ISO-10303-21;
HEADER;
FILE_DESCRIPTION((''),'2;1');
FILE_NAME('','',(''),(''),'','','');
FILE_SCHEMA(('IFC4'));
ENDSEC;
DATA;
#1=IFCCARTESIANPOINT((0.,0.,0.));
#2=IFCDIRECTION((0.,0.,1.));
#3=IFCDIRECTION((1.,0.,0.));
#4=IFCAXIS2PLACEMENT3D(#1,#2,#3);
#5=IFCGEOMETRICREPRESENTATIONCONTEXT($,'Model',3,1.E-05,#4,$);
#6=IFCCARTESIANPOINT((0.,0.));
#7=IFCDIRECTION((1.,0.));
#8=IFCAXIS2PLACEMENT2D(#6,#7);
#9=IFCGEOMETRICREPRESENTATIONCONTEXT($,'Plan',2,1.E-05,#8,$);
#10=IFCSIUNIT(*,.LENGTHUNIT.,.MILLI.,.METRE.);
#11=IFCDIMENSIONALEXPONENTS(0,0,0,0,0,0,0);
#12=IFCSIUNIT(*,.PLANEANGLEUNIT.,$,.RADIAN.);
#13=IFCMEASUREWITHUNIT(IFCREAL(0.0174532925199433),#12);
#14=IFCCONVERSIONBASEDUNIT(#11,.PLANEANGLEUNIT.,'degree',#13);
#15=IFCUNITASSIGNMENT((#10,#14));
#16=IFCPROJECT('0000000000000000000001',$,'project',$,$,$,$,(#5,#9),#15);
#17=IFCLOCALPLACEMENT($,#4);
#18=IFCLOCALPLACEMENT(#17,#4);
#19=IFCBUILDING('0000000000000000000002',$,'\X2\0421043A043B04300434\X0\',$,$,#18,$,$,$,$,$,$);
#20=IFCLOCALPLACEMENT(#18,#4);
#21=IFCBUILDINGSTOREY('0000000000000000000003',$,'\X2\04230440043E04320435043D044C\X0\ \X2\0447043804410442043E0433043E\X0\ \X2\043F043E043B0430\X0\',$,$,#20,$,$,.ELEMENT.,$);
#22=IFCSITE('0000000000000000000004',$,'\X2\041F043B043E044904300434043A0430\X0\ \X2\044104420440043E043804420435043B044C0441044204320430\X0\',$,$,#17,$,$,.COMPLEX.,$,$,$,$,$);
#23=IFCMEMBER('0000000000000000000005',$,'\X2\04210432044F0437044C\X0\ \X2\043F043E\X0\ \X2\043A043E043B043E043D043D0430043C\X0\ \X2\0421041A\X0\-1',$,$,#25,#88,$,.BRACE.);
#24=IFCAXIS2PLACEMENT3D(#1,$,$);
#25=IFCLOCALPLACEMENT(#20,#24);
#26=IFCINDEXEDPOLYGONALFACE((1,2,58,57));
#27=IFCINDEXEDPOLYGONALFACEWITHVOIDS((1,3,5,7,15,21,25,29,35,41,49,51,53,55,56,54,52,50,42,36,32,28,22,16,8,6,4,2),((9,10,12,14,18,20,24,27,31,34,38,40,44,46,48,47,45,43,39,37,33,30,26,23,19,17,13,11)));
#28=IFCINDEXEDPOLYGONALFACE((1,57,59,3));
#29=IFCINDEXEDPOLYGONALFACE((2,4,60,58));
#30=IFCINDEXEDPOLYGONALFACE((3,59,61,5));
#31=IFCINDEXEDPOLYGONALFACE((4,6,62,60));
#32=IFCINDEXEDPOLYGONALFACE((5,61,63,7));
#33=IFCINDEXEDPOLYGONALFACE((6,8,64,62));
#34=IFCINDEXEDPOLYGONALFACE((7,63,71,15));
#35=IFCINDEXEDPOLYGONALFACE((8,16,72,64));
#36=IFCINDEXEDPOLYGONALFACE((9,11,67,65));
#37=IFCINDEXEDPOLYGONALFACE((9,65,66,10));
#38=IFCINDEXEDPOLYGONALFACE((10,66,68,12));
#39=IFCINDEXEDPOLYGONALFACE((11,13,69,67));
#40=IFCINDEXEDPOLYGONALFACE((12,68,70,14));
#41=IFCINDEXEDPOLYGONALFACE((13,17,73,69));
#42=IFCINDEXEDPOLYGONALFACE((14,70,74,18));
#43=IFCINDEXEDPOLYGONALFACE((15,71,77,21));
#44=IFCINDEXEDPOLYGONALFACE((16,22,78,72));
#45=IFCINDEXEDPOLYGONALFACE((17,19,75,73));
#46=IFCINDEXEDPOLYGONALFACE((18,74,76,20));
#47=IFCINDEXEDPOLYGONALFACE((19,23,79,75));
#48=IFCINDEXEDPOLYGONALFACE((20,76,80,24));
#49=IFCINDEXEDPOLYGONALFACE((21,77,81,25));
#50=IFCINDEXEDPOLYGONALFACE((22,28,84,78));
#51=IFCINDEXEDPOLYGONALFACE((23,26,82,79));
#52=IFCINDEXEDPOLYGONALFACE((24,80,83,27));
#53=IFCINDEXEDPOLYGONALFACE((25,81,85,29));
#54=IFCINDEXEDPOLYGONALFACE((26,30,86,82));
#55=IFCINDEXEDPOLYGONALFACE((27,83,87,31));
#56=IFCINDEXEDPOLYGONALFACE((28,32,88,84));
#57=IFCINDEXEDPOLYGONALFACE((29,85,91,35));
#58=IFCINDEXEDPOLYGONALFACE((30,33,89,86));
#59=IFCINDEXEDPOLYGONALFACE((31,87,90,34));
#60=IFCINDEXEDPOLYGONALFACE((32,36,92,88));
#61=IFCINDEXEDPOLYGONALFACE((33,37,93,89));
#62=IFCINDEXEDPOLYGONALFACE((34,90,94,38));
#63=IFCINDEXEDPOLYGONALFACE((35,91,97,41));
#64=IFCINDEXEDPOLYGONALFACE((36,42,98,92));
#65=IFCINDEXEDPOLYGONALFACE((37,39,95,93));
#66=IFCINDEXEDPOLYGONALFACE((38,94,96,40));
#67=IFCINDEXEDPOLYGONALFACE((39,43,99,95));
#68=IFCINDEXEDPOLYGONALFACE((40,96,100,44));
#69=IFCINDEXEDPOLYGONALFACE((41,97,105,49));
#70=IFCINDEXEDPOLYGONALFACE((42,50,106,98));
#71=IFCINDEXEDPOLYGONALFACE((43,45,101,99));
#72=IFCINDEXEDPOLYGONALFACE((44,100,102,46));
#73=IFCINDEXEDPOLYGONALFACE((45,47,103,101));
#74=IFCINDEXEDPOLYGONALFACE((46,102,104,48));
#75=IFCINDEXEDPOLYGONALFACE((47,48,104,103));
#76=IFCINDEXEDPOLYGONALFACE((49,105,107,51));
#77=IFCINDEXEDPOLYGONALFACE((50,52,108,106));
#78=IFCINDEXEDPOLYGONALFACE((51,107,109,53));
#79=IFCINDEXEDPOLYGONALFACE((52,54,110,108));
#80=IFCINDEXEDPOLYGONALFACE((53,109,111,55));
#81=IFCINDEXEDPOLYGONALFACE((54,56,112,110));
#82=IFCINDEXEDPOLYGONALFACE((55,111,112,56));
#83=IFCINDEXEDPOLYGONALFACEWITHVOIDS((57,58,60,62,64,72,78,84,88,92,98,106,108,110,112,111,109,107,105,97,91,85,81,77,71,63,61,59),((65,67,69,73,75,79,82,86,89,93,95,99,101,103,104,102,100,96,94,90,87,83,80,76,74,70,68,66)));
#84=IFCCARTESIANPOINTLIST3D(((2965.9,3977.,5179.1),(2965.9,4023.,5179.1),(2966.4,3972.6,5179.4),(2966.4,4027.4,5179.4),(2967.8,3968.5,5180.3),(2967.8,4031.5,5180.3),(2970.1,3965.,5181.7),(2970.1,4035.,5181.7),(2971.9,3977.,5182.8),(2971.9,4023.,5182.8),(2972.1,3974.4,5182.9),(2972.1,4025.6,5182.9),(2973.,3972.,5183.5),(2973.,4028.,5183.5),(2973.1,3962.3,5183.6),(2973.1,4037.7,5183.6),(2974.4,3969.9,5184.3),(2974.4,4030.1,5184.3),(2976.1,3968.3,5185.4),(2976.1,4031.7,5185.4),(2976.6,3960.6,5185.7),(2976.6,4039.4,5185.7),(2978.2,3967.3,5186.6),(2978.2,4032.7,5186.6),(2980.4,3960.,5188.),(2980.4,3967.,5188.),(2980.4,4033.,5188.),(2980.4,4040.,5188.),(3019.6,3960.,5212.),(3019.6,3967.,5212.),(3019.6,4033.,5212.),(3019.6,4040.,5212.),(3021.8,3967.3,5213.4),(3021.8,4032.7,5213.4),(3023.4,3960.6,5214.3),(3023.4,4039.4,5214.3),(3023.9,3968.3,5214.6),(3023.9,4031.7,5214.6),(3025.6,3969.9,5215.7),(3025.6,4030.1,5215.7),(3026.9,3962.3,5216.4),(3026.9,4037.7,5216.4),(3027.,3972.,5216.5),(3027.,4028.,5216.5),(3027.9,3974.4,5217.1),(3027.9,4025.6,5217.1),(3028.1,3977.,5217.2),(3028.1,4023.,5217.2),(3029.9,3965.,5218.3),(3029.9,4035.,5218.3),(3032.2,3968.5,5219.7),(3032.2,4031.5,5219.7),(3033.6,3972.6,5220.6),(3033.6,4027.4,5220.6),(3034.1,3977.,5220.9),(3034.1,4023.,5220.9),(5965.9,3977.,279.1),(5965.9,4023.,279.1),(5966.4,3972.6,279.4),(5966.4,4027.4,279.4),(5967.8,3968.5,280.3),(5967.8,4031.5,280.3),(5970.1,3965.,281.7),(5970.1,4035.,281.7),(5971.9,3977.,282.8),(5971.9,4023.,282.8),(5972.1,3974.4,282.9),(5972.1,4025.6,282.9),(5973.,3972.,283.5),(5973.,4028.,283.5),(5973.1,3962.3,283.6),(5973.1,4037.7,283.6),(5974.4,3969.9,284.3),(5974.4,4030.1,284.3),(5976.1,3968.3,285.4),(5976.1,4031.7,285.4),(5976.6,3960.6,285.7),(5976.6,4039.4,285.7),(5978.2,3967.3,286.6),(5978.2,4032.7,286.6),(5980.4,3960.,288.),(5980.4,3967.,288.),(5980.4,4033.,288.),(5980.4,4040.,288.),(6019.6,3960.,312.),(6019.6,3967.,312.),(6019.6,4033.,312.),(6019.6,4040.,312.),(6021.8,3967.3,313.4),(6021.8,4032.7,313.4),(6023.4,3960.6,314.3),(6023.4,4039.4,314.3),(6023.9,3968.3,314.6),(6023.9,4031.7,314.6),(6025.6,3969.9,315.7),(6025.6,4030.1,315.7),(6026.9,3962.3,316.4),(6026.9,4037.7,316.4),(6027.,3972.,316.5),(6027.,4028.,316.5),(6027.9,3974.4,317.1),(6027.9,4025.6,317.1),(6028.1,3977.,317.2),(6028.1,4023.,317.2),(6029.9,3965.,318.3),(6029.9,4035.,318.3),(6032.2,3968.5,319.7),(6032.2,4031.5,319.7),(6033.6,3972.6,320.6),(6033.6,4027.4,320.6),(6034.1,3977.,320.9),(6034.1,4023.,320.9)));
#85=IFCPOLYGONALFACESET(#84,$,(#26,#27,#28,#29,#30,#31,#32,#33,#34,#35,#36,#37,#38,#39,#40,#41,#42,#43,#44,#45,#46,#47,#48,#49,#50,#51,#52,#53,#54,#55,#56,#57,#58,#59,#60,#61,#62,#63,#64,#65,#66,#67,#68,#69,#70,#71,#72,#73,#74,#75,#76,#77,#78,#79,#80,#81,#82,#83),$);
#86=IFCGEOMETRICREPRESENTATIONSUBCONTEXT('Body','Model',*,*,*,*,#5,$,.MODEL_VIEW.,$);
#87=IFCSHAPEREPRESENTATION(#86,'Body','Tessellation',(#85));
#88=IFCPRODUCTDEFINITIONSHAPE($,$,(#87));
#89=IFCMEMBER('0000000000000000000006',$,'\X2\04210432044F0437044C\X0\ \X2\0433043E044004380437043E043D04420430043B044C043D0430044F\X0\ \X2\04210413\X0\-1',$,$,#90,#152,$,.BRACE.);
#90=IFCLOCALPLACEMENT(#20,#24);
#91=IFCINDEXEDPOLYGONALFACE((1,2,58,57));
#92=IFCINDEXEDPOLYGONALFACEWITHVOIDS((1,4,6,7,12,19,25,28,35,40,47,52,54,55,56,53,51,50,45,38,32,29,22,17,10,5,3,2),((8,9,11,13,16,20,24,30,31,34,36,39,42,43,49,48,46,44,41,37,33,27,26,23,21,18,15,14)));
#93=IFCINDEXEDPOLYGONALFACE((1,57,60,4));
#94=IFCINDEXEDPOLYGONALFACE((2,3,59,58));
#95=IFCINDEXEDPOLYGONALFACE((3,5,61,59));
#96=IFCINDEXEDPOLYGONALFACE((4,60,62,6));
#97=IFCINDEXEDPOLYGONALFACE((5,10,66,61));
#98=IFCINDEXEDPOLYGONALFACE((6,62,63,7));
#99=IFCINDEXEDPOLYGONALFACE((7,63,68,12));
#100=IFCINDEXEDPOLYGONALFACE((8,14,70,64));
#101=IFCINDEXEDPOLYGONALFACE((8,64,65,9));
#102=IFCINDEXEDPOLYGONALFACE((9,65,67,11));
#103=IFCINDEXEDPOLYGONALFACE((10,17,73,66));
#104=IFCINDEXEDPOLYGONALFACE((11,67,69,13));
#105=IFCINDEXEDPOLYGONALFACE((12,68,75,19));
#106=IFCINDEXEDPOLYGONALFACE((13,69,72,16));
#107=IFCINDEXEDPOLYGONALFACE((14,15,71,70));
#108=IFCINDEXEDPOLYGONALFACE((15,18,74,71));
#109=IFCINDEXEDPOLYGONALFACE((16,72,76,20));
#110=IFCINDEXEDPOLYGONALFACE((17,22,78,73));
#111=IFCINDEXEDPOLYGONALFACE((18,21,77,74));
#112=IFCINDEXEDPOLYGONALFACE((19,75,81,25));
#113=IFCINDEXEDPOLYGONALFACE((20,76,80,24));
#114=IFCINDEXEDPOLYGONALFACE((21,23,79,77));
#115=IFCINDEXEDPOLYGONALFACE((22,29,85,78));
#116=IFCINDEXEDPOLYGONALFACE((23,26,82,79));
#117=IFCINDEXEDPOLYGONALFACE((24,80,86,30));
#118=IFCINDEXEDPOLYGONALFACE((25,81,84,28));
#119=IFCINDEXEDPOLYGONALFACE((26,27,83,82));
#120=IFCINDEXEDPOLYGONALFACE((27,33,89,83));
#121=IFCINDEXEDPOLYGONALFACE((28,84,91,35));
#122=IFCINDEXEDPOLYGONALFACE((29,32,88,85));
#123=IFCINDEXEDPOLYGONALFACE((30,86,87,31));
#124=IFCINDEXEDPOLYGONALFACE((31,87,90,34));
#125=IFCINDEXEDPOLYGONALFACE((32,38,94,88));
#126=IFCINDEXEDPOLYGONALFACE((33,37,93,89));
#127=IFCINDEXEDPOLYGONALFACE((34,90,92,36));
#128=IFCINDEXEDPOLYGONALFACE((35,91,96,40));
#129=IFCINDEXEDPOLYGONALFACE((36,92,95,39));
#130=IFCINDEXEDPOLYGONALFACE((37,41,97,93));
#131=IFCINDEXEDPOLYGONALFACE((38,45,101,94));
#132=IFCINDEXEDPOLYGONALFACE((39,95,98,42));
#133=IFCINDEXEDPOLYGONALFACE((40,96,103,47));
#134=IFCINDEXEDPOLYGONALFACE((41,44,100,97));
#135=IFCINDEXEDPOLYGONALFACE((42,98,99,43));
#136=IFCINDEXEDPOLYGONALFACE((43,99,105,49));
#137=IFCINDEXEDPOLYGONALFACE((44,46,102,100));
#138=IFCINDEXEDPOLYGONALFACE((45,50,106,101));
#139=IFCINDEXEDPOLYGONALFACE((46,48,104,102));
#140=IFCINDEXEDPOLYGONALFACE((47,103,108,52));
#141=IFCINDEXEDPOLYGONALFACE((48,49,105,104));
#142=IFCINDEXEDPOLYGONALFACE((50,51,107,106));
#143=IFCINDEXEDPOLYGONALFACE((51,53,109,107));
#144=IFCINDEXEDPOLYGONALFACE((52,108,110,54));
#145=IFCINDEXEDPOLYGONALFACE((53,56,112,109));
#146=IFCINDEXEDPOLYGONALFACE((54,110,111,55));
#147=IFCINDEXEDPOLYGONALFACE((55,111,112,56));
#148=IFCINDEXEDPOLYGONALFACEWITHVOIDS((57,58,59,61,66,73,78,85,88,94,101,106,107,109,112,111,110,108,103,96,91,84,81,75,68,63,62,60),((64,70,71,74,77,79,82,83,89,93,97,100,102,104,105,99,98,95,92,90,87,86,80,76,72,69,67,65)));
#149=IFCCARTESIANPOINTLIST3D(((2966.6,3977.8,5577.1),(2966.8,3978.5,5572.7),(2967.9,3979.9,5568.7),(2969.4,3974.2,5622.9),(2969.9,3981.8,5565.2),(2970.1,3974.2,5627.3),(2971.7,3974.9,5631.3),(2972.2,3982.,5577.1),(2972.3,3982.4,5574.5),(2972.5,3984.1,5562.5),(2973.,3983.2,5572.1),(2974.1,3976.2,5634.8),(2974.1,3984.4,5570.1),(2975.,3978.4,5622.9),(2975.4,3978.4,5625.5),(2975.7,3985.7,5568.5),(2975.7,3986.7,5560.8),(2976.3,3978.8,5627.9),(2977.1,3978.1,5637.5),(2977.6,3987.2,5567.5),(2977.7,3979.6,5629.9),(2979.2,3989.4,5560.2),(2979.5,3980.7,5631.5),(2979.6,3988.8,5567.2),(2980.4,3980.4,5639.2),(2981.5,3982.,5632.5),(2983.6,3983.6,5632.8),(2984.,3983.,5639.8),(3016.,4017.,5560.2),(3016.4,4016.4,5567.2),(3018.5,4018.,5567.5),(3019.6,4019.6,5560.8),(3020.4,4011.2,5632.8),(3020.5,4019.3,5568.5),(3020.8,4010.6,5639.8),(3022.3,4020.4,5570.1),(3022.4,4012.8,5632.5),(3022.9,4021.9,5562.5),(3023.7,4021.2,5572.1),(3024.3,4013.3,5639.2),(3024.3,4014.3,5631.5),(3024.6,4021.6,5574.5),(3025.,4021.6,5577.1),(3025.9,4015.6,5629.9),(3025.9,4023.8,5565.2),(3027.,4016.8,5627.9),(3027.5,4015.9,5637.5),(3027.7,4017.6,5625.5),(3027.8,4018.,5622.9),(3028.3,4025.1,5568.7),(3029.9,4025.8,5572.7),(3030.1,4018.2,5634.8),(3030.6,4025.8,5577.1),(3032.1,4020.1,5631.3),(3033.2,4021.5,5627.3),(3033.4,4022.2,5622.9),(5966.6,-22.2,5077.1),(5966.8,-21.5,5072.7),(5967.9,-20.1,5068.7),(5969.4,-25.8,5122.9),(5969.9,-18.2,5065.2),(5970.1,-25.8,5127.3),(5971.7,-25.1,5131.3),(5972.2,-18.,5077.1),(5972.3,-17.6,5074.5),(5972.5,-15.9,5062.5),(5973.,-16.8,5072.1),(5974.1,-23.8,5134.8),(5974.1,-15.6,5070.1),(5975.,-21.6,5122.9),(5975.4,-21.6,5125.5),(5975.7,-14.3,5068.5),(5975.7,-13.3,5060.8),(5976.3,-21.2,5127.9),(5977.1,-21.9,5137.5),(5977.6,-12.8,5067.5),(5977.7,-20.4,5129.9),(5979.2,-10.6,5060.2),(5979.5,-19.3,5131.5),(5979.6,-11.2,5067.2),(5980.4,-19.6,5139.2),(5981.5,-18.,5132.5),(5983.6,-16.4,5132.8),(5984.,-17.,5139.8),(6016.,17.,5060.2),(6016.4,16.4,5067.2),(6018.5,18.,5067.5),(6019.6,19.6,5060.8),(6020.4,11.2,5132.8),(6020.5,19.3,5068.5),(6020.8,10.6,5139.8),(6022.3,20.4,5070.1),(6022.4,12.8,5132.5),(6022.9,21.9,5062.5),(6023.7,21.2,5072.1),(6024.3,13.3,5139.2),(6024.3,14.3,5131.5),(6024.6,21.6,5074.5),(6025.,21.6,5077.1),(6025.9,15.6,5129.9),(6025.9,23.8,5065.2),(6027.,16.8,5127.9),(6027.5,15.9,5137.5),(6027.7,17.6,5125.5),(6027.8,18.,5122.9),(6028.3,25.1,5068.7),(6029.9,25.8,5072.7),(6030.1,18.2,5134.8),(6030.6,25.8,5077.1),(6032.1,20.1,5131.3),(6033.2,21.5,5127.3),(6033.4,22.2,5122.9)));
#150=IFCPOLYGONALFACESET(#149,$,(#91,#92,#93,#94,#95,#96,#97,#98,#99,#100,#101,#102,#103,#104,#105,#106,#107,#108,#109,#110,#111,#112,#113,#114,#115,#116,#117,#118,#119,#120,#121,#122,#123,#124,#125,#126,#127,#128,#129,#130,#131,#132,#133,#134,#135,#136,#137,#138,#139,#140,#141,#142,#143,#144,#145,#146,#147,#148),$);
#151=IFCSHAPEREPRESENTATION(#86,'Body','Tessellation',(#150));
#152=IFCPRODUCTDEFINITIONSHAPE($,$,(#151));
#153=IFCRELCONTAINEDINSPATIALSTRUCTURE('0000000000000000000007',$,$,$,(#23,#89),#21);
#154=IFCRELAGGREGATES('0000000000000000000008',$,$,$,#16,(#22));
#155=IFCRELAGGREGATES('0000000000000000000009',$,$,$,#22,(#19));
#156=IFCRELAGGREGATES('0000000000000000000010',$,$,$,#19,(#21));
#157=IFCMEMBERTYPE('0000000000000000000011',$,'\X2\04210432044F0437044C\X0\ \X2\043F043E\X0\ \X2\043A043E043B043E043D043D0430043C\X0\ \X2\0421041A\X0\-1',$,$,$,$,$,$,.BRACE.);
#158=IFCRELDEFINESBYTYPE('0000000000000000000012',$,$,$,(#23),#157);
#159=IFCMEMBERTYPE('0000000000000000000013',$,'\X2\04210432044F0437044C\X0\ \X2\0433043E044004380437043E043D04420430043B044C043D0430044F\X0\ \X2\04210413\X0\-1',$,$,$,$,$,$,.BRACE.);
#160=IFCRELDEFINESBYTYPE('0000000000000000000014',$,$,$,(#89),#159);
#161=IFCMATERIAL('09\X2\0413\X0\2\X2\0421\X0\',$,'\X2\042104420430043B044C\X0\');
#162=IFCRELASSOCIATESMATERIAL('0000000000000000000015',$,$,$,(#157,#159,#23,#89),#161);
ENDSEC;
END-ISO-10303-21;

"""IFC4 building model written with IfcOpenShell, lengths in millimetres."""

from ifc_helpers import new_model, entity, si_unit, converted_unit, frame, origin_with_axes, origin_2d_with_axis, place, context, subcontext, project, spatial, hollow_rectangle, extrude, material, material_profile, profile_set, profile_usage, type_object, element, save


model = new_model("IFC4")

# Units and contexts
model_context = context("Model", 3, precision=1e-05, world=origin_with_axes())
plan_context = context("Plan", 2, precision=1e-05, world=origin_2d_with_axis())
body_context = subcontext(model_context, "Body", "Model", "MODEL_VIEW")
ifc_project = project(units=[si_unit("LENGTHUNIT", "METRE", prefix="MILLI"), converted_unit("PLANEANGLEUNIT", "degree", entity("IfcReal", 0.0174532925199433), si_unit("PLANEANGLEUNIT", "RADIAN"), dimensions=[0, 0, 0, 0, 0, 0, 0])], contexts=[model_context, plan_context])

# Site, building, storey
site_placement = place(None, origin_with_axes())
site = spatial("IfcSite", under=ifc_project, at=site_placement, Name="Площадка строительства", CompositionType="COMPLEX")
building_placement = place(site_placement, origin_with_axes())
building = spatial("IfcBuilding", under=site, at=building_placement, Name="Склад")
storey_placement = place(building_placement, origin_with_axes())
storey = spatial("IfcBuildingStorey", under=building, at=storey_placement, Name="Уровень чистого пола", CompositionType="ELEMENT")

# Members
ifc_material_1 = material(Name="09Г2С", Category="Сталь")
ifc_material_profile_1 = material_profile(ifc_material_1, hollow_rectangle(XDim=80.0, YDim=80.0, WallThickness=7.0, InnerFilletRadius=10.0, OuterFilletRadius=17.0))
ifc_profile_set_1 = profile_set([ifc_material_profile_1], Name="PK80x7_09G2S")
ifc_profile_usage_1 = profile_usage(ifc_profile_set_1, cardinal=5)
member_type_1 = type_object("IfcMemberType", Name="Связь по колоннам СК-1", PredefinedType="BRACE", material=ifc_profile_set_1)
member_1_placement = place(storey_placement, frame((6000.0, 4000.0, 300.0), z_axis=(-0.522154, 0.0, 0.852851), x_axis=(0.0, -1.0, 0.0)))
element("IfcMember", 1, at=member_1_placement, inside=storey, type_object=member_type_1, material=ifc_profile_usage_1, Name="Связь по колоннам СК-1", PredefinedType="BRACE", context=body_context, shape_type="SweptSolid", body=[
    extrude(hollow_rectangle(XDim=80.0, YDim=80.0, WallThickness=7.0, InnerFilletRadius=10.0, OuterFilletRadius=17.0), origin_with_axes(), (0.0, 0.0, 1.0), 5745.4),
])
member_type_2 = type_object("IfcMemberType", Name="Связь горизонтальная СГ-1", PredefinedType="BRACE", material=ifc_profile_set_1)
member_2_placement = place(storey_placement, frame((6000.0, 0.0, 5100.0), z_axis=(-0.597022, 0.79603, 0.099504), x_axis=(-0.8, -0.6, 0.0)))
element("IfcMember", 2, at=member_2_placement, inside=storey, type_object=member_type_2, material=ifc_profile_usage_1, Name="Связь горизонтальная СГ-1", PredefinedType="BRACE", context=body_context, shape_type="SweptSolid", body=[
    extrude(hollow_rectangle(XDim=80.0, YDim=80.0, WallThickness=7.0, InnerFilletRadius=10.0, OuterFilletRadius=17.0), origin_with_axes(), (0.0, 0.0, 1.0), 5024.9),
])

save(model, "model.ifc")
